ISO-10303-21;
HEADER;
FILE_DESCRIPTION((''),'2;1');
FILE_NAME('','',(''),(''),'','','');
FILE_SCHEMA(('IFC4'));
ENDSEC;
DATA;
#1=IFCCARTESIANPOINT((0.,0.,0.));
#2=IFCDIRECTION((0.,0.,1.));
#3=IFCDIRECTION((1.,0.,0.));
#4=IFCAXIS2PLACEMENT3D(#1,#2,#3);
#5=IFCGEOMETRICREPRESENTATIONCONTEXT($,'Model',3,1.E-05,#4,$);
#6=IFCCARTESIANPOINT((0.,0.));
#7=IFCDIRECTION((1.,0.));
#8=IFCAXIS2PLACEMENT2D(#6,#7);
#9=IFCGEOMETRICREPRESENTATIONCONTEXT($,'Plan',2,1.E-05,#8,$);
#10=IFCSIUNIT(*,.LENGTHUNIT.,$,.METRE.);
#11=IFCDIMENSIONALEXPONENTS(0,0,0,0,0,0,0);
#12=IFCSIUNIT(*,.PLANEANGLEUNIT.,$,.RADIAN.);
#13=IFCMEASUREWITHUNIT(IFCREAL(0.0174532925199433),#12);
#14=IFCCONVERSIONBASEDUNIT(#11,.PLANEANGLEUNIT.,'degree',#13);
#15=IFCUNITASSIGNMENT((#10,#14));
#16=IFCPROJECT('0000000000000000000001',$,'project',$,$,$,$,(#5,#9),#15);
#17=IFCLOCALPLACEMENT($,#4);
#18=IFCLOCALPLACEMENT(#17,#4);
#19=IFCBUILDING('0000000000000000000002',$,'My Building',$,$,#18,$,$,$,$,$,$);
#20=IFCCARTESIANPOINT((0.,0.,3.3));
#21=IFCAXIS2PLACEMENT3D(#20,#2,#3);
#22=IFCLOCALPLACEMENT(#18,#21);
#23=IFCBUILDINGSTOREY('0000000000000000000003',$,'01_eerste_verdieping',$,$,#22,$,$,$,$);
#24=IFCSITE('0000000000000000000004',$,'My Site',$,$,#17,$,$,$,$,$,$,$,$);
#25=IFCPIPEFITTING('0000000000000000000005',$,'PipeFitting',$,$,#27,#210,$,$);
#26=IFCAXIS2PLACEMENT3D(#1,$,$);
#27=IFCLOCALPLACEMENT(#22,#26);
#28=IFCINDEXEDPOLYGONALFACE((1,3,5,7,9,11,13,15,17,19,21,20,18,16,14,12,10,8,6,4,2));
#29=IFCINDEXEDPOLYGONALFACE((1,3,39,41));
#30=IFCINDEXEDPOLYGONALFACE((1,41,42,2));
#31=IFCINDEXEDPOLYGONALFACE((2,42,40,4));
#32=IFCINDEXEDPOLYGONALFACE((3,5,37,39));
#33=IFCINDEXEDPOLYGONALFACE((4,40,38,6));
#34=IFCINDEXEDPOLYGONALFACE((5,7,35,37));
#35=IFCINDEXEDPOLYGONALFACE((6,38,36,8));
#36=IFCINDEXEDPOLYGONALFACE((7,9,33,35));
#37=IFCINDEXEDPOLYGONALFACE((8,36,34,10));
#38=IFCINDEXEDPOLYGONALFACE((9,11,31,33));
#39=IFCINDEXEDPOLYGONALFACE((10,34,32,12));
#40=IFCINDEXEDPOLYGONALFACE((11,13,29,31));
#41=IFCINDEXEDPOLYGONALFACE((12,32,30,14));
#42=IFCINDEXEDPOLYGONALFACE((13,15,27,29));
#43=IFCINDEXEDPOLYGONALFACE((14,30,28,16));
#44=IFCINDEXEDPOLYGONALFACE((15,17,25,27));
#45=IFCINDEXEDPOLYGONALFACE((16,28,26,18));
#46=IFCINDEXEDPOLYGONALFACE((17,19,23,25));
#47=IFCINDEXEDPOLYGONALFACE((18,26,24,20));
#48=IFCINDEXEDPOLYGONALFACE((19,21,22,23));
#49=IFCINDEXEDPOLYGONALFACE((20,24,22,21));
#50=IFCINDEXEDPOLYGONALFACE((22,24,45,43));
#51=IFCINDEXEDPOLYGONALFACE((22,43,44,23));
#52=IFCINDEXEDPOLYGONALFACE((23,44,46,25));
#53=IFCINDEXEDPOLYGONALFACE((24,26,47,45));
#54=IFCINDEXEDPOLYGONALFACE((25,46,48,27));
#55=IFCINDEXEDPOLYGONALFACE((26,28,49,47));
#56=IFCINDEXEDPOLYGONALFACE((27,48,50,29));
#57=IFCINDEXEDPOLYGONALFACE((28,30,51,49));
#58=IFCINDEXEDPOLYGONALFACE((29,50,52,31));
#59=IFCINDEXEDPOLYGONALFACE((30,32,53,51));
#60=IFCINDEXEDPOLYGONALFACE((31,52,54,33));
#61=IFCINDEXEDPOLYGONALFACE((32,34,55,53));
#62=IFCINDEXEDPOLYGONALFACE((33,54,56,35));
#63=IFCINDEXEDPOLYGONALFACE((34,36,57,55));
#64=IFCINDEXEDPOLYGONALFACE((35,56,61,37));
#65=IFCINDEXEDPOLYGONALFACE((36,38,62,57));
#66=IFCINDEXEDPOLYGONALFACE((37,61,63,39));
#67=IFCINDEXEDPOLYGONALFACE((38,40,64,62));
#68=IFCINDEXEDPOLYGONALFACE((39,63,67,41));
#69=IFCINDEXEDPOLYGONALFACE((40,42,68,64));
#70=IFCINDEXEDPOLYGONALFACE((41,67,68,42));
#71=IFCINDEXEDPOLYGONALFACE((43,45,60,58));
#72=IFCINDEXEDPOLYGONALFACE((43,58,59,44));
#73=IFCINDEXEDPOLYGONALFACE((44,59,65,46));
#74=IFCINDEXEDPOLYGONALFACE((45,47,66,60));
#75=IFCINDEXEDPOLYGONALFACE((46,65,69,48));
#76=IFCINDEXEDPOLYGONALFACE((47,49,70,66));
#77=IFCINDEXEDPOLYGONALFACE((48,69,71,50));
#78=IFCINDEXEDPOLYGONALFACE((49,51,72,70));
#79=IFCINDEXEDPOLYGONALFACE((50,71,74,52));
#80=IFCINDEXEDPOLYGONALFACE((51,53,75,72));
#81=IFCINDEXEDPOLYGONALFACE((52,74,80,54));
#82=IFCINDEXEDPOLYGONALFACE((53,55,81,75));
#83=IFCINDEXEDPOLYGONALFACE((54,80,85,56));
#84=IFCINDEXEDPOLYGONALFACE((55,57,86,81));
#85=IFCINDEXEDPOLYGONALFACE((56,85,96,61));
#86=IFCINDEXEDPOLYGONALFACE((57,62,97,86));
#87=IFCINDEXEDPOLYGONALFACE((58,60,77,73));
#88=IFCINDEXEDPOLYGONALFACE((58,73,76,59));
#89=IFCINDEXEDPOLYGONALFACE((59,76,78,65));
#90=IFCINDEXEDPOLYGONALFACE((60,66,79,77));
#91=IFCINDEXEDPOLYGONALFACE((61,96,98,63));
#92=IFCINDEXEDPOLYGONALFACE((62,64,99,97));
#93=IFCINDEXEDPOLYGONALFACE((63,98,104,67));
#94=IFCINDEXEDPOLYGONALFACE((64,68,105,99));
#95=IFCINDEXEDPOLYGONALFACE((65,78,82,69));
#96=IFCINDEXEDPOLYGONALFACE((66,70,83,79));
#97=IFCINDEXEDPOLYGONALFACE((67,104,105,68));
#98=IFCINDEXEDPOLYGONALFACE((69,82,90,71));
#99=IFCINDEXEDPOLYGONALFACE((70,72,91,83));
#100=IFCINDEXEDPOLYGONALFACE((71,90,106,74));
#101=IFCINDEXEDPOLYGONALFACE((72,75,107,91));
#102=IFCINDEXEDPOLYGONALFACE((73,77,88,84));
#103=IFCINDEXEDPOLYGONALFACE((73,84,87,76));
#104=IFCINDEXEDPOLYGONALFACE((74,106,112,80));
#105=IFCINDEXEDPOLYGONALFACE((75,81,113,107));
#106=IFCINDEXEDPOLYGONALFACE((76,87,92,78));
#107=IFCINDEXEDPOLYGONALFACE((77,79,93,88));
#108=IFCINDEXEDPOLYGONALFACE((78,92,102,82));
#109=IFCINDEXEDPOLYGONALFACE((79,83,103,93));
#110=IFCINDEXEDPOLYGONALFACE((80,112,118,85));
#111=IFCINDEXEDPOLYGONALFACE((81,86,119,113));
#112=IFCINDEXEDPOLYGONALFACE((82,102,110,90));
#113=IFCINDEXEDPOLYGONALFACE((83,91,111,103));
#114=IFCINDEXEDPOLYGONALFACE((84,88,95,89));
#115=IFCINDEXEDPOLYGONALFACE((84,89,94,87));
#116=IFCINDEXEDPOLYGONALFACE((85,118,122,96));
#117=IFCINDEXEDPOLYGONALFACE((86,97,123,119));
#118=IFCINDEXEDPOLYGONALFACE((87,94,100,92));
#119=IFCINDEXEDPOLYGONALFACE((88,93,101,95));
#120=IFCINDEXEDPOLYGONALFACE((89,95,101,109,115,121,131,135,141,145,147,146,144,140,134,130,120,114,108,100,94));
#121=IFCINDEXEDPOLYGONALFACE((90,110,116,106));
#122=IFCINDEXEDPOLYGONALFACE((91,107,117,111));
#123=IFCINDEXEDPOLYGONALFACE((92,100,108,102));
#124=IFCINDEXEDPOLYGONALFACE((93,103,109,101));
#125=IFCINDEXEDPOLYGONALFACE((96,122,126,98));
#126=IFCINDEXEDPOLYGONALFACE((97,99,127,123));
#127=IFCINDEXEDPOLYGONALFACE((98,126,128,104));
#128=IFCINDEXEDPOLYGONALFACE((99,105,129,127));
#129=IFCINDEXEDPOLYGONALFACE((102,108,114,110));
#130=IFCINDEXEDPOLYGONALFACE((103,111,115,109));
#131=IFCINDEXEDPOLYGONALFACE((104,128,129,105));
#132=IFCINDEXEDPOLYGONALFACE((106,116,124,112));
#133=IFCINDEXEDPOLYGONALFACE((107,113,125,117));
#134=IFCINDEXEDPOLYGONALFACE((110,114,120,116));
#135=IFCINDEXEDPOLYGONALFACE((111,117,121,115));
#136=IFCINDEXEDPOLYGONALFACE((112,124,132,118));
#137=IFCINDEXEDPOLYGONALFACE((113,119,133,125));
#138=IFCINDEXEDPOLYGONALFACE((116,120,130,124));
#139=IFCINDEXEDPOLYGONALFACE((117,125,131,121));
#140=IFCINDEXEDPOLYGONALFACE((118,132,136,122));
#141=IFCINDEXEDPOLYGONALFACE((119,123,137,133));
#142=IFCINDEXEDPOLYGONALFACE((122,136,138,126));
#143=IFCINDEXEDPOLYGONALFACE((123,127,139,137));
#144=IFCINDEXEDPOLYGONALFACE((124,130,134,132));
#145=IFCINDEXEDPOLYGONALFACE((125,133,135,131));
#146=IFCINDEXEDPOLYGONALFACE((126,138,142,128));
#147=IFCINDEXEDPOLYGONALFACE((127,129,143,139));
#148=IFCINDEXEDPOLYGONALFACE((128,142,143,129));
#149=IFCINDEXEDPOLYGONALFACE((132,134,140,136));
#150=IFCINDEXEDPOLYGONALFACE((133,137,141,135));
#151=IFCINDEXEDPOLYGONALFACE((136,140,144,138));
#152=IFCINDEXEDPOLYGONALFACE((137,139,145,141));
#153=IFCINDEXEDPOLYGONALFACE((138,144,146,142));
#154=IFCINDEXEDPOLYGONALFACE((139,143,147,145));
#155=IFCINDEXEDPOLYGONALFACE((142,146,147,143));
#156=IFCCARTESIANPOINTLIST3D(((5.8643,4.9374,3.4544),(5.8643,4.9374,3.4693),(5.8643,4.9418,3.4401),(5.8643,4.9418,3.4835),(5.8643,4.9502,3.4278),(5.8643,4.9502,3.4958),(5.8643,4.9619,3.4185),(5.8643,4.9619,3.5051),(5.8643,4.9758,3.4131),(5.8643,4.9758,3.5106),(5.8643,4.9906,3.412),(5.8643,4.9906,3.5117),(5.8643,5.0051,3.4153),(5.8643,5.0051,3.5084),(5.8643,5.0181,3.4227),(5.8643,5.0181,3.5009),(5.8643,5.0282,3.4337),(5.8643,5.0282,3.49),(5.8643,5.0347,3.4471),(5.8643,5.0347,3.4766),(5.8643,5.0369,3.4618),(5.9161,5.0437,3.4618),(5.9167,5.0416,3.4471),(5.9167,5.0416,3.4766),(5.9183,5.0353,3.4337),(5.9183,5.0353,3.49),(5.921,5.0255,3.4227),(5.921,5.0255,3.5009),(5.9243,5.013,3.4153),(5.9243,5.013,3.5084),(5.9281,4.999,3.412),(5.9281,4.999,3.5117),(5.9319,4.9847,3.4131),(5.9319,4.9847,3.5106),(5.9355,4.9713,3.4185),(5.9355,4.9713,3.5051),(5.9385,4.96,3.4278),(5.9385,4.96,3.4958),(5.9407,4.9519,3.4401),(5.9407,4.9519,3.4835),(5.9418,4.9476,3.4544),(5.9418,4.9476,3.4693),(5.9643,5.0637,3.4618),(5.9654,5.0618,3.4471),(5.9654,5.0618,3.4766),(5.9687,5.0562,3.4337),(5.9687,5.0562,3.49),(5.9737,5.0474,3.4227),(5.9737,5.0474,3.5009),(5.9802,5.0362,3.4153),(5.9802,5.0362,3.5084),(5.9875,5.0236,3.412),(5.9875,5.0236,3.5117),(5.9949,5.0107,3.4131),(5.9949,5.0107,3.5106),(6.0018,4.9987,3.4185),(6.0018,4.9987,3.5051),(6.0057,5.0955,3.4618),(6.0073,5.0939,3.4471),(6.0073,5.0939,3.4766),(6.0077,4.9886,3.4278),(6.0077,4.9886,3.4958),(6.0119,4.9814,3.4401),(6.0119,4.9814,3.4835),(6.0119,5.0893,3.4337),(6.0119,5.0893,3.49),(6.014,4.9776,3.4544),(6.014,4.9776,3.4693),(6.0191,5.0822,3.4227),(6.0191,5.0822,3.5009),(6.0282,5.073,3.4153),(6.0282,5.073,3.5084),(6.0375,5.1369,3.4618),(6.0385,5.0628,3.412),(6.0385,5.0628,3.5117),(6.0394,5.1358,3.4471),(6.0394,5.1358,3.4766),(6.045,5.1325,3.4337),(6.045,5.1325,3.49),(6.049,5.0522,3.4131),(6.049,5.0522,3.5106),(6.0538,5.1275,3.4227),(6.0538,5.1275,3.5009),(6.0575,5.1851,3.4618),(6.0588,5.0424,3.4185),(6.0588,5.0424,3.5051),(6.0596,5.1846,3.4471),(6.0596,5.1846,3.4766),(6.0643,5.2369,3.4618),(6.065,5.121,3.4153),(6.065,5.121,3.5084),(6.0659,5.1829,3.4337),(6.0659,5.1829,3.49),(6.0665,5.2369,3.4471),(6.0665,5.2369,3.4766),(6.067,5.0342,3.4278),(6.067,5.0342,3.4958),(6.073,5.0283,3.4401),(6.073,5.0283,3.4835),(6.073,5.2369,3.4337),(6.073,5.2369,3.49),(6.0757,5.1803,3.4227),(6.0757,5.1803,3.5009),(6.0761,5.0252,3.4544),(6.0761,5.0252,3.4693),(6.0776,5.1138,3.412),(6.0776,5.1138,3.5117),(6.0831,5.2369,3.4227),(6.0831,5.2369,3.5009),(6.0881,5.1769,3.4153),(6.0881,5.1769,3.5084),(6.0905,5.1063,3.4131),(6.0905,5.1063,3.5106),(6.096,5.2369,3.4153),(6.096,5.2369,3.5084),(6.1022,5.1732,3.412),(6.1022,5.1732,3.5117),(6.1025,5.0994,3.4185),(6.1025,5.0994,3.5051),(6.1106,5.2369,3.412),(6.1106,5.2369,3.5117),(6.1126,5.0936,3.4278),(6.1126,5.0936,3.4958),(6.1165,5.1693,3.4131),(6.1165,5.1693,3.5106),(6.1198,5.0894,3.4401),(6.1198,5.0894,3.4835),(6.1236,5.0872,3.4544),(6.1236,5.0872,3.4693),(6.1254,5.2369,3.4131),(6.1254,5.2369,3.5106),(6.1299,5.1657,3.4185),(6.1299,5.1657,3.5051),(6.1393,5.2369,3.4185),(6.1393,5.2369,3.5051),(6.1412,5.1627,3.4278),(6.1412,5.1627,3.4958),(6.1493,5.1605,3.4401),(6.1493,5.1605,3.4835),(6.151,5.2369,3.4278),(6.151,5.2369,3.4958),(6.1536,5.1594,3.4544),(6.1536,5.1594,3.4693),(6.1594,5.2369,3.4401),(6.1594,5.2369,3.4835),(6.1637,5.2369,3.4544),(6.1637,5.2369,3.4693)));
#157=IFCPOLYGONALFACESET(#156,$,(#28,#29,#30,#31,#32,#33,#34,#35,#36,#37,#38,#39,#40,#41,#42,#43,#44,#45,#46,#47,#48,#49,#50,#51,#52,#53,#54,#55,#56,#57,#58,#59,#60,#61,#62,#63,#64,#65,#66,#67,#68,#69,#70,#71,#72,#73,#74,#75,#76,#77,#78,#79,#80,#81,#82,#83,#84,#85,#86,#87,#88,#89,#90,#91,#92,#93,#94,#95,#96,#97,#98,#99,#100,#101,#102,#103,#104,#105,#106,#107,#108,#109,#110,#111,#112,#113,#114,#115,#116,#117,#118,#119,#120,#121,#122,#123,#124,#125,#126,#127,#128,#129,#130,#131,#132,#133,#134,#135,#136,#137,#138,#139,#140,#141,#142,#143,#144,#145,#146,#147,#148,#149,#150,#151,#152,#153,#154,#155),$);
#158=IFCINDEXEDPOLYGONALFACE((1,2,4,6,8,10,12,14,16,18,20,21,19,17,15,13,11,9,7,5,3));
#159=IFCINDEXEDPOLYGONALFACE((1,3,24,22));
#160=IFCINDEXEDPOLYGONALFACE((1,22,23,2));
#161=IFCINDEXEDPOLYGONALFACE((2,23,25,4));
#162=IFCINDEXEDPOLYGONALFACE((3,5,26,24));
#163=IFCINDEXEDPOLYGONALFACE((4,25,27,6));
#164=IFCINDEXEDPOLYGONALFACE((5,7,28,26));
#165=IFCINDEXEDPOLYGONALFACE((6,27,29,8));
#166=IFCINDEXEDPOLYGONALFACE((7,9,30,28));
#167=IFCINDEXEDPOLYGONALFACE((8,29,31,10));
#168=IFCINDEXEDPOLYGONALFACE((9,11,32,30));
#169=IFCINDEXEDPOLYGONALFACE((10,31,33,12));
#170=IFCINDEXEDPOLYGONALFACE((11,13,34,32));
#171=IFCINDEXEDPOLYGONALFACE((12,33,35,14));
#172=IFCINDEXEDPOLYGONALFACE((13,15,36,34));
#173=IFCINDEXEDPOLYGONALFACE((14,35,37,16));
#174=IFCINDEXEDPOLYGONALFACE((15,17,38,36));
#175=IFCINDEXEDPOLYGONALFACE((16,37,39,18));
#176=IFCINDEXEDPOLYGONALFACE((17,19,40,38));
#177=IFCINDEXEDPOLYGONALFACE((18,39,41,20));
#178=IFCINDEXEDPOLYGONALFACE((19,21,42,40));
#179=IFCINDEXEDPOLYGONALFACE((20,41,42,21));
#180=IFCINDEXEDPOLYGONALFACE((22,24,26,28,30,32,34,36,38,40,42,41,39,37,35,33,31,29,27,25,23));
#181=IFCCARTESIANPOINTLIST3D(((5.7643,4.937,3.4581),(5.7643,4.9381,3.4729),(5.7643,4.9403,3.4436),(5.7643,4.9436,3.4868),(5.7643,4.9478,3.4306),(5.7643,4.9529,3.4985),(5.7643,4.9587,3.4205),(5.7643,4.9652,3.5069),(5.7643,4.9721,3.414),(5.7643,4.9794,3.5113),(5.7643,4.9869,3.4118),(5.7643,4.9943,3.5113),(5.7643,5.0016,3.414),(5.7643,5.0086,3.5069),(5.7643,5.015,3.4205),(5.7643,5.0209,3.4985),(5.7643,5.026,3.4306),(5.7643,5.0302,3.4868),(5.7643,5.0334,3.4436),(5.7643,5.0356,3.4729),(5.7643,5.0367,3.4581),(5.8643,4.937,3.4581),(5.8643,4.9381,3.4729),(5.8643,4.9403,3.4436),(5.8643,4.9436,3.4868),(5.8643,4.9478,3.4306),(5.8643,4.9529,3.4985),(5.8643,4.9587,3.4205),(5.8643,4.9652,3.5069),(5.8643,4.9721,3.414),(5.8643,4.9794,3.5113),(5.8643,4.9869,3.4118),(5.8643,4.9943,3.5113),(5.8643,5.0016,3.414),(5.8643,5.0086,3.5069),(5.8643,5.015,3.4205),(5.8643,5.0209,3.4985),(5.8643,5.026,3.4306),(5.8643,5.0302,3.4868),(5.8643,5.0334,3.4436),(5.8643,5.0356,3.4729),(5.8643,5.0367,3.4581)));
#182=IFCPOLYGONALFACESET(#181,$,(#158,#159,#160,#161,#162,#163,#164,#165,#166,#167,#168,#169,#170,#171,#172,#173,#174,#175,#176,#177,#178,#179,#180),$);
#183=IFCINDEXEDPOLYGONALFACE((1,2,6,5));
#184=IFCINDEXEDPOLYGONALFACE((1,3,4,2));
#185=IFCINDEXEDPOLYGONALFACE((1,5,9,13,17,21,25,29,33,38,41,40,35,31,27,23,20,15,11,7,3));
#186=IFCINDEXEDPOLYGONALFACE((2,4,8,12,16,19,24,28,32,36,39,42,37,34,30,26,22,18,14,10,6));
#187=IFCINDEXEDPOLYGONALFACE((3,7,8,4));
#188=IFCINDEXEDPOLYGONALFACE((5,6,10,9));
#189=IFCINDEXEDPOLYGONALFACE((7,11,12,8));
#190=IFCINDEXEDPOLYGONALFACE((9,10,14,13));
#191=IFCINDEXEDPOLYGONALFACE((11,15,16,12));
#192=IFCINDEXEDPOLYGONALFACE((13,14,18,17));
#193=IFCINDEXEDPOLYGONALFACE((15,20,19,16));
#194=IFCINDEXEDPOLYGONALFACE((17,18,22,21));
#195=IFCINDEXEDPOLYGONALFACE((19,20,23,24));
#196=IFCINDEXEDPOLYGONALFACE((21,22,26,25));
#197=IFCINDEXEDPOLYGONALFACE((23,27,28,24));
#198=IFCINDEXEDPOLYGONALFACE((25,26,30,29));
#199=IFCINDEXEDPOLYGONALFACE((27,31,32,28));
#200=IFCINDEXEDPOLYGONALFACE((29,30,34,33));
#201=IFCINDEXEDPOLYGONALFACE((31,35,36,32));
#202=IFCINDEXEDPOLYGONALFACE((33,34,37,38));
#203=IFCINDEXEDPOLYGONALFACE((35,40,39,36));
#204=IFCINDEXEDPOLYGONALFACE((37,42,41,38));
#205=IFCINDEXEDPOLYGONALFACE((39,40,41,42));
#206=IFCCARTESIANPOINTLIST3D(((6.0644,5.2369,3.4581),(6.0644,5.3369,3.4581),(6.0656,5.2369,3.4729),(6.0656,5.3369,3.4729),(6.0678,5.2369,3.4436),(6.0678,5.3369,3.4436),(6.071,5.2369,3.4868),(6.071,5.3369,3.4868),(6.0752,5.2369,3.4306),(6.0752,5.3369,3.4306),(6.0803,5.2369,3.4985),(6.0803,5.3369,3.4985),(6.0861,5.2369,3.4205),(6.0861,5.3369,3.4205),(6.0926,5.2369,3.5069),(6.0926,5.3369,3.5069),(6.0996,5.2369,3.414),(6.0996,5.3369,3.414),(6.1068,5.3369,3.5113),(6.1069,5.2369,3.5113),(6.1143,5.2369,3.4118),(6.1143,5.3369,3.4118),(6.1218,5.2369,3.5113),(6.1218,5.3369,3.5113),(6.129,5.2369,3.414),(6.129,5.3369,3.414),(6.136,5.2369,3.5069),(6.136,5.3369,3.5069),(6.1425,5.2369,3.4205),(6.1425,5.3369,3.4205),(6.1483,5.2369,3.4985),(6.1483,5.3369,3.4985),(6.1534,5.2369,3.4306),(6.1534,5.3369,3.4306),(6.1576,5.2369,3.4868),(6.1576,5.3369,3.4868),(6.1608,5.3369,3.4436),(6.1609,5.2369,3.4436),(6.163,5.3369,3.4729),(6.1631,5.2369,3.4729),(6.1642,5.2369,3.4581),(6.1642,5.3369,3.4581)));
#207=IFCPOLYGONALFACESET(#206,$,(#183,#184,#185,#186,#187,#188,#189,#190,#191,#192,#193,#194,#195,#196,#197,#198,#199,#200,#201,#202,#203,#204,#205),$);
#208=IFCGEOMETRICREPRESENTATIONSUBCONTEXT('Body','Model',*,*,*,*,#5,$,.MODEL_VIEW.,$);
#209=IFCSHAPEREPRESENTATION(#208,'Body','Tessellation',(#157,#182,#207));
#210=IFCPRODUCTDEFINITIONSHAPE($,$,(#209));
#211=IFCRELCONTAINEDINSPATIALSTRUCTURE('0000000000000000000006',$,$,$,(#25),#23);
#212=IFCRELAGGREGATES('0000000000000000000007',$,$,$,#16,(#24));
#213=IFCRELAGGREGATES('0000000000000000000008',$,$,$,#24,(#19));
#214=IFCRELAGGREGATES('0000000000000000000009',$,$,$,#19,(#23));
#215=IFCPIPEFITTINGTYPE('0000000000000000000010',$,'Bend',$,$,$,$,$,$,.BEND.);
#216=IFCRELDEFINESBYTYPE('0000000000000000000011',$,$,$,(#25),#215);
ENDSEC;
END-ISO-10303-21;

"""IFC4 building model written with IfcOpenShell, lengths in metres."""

from ifc_helpers import new_model, entity, si_unit, converted_unit, frame, origin_with_axes, origin_2d_with_axis, place, context, subcontext, project, spatial, circle, extrude, source, transform, mapped, type_object, type_shapes, element, save


model = new_model("IFC4")

# Units and contexts
model_context = context("Model", 3, precision=1e-05, world=origin_with_axes())
plan_context = context("Plan", 2, precision=1e-05, world=origin_2d_with_axis())
body_context_1 = subcontext(model_context, "Body", "Model", "MODEL_VIEW")
ifc_project = project(units=[si_unit("LENGTHUNIT", "METRE"), converted_unit("PLANEANGLEUNIT", "degree", entity("IfcReal", 0.0174532925199433), si_unit("PLANEANGLEUNIT", "RADIAN"), dimensions=[0, 0, 0, 0, 0, 0, 0])], contexts=[model_context, plan_context])

# Site, building, storey
site_placement = place(None, origin_with_axes())
site = spatial("IfcSite", under=ifc_project, at=site_placement, Name="My Site")
building_placement = place(site_placement, origin_with_axes())
building = spatial("IfcBuilding", under=site, at=building_placement, Name="My Building")
storey_placement = place(building_placement, frame((0.0, 0.0, 3.3), z_axis=(0.0, 0.0, 1.0), x_axis=(1.0, 0.0, 0.0)))
storey = spatial("IfcBuildingStorey", under=building, at=storey_placement, Name="01_eerste_verdieping")

# Pipe fitting
pipe_fitting_type = type_object("IfcPipeFittingType", Name="Bend", PredefinedType="BEND")
shared_shape_1 = source(origin_with_axes(), body_context_1, "Body", "AdvancedSweptSolid", [
    entity("IfcSweptDiskSolid", entity("IfcIndexedPolyCurve", entity("IfcCartesianPointList3D", [[0.0, 0.0, -0.1], [0.0, -0.0732, -0.2768], [0.0, -0.25, -0.35]]), [entity("IfcArcIndex", [1, 2, 3])]), 0.05),
    extrude(circle(Radius=0.05), origin_with_axes(), (0.0, 0.0, -1.0), 0.1),
    extrude(circle(Radius=0.05), frame((0.0, -0.25, -0.35), z_axis=(0.0, -1.0, 0.0), x_axis=(1.0, 0.0, 0.0)), (0.0, 0.0, 1.0), 0.1),
])
type_shapes(pipe_fitting_type, [shared_shape_1])
for number, where, z_axis, x_axis, name in (
    (1, (5.7643, 4.9869, 3.4618), (-1.0, -0.000073, 0.0), (0.0, 0.0, -1.0), "PipeFitting"),
):
    element("IfcPipeFitting", number, at=place(storey_placement, frame(where, z_axis=z_axis, x_axis=x_axis)), inside=storey, type_object=pipe_fitting_type, Name=name, context=body_context_1, shape_type="MappedRepresentation", body=[
        mapped(shared_shape_1, transform((0.0, 0.0, 0.0), x_axis=(1.0, 0.0, 0.0), y_axis=(0.0, 1.0, 0.0), z_axis=(0.0, 0.0, 1.0), scale=1.0)),
    ])

save(model, "model.ifc")
